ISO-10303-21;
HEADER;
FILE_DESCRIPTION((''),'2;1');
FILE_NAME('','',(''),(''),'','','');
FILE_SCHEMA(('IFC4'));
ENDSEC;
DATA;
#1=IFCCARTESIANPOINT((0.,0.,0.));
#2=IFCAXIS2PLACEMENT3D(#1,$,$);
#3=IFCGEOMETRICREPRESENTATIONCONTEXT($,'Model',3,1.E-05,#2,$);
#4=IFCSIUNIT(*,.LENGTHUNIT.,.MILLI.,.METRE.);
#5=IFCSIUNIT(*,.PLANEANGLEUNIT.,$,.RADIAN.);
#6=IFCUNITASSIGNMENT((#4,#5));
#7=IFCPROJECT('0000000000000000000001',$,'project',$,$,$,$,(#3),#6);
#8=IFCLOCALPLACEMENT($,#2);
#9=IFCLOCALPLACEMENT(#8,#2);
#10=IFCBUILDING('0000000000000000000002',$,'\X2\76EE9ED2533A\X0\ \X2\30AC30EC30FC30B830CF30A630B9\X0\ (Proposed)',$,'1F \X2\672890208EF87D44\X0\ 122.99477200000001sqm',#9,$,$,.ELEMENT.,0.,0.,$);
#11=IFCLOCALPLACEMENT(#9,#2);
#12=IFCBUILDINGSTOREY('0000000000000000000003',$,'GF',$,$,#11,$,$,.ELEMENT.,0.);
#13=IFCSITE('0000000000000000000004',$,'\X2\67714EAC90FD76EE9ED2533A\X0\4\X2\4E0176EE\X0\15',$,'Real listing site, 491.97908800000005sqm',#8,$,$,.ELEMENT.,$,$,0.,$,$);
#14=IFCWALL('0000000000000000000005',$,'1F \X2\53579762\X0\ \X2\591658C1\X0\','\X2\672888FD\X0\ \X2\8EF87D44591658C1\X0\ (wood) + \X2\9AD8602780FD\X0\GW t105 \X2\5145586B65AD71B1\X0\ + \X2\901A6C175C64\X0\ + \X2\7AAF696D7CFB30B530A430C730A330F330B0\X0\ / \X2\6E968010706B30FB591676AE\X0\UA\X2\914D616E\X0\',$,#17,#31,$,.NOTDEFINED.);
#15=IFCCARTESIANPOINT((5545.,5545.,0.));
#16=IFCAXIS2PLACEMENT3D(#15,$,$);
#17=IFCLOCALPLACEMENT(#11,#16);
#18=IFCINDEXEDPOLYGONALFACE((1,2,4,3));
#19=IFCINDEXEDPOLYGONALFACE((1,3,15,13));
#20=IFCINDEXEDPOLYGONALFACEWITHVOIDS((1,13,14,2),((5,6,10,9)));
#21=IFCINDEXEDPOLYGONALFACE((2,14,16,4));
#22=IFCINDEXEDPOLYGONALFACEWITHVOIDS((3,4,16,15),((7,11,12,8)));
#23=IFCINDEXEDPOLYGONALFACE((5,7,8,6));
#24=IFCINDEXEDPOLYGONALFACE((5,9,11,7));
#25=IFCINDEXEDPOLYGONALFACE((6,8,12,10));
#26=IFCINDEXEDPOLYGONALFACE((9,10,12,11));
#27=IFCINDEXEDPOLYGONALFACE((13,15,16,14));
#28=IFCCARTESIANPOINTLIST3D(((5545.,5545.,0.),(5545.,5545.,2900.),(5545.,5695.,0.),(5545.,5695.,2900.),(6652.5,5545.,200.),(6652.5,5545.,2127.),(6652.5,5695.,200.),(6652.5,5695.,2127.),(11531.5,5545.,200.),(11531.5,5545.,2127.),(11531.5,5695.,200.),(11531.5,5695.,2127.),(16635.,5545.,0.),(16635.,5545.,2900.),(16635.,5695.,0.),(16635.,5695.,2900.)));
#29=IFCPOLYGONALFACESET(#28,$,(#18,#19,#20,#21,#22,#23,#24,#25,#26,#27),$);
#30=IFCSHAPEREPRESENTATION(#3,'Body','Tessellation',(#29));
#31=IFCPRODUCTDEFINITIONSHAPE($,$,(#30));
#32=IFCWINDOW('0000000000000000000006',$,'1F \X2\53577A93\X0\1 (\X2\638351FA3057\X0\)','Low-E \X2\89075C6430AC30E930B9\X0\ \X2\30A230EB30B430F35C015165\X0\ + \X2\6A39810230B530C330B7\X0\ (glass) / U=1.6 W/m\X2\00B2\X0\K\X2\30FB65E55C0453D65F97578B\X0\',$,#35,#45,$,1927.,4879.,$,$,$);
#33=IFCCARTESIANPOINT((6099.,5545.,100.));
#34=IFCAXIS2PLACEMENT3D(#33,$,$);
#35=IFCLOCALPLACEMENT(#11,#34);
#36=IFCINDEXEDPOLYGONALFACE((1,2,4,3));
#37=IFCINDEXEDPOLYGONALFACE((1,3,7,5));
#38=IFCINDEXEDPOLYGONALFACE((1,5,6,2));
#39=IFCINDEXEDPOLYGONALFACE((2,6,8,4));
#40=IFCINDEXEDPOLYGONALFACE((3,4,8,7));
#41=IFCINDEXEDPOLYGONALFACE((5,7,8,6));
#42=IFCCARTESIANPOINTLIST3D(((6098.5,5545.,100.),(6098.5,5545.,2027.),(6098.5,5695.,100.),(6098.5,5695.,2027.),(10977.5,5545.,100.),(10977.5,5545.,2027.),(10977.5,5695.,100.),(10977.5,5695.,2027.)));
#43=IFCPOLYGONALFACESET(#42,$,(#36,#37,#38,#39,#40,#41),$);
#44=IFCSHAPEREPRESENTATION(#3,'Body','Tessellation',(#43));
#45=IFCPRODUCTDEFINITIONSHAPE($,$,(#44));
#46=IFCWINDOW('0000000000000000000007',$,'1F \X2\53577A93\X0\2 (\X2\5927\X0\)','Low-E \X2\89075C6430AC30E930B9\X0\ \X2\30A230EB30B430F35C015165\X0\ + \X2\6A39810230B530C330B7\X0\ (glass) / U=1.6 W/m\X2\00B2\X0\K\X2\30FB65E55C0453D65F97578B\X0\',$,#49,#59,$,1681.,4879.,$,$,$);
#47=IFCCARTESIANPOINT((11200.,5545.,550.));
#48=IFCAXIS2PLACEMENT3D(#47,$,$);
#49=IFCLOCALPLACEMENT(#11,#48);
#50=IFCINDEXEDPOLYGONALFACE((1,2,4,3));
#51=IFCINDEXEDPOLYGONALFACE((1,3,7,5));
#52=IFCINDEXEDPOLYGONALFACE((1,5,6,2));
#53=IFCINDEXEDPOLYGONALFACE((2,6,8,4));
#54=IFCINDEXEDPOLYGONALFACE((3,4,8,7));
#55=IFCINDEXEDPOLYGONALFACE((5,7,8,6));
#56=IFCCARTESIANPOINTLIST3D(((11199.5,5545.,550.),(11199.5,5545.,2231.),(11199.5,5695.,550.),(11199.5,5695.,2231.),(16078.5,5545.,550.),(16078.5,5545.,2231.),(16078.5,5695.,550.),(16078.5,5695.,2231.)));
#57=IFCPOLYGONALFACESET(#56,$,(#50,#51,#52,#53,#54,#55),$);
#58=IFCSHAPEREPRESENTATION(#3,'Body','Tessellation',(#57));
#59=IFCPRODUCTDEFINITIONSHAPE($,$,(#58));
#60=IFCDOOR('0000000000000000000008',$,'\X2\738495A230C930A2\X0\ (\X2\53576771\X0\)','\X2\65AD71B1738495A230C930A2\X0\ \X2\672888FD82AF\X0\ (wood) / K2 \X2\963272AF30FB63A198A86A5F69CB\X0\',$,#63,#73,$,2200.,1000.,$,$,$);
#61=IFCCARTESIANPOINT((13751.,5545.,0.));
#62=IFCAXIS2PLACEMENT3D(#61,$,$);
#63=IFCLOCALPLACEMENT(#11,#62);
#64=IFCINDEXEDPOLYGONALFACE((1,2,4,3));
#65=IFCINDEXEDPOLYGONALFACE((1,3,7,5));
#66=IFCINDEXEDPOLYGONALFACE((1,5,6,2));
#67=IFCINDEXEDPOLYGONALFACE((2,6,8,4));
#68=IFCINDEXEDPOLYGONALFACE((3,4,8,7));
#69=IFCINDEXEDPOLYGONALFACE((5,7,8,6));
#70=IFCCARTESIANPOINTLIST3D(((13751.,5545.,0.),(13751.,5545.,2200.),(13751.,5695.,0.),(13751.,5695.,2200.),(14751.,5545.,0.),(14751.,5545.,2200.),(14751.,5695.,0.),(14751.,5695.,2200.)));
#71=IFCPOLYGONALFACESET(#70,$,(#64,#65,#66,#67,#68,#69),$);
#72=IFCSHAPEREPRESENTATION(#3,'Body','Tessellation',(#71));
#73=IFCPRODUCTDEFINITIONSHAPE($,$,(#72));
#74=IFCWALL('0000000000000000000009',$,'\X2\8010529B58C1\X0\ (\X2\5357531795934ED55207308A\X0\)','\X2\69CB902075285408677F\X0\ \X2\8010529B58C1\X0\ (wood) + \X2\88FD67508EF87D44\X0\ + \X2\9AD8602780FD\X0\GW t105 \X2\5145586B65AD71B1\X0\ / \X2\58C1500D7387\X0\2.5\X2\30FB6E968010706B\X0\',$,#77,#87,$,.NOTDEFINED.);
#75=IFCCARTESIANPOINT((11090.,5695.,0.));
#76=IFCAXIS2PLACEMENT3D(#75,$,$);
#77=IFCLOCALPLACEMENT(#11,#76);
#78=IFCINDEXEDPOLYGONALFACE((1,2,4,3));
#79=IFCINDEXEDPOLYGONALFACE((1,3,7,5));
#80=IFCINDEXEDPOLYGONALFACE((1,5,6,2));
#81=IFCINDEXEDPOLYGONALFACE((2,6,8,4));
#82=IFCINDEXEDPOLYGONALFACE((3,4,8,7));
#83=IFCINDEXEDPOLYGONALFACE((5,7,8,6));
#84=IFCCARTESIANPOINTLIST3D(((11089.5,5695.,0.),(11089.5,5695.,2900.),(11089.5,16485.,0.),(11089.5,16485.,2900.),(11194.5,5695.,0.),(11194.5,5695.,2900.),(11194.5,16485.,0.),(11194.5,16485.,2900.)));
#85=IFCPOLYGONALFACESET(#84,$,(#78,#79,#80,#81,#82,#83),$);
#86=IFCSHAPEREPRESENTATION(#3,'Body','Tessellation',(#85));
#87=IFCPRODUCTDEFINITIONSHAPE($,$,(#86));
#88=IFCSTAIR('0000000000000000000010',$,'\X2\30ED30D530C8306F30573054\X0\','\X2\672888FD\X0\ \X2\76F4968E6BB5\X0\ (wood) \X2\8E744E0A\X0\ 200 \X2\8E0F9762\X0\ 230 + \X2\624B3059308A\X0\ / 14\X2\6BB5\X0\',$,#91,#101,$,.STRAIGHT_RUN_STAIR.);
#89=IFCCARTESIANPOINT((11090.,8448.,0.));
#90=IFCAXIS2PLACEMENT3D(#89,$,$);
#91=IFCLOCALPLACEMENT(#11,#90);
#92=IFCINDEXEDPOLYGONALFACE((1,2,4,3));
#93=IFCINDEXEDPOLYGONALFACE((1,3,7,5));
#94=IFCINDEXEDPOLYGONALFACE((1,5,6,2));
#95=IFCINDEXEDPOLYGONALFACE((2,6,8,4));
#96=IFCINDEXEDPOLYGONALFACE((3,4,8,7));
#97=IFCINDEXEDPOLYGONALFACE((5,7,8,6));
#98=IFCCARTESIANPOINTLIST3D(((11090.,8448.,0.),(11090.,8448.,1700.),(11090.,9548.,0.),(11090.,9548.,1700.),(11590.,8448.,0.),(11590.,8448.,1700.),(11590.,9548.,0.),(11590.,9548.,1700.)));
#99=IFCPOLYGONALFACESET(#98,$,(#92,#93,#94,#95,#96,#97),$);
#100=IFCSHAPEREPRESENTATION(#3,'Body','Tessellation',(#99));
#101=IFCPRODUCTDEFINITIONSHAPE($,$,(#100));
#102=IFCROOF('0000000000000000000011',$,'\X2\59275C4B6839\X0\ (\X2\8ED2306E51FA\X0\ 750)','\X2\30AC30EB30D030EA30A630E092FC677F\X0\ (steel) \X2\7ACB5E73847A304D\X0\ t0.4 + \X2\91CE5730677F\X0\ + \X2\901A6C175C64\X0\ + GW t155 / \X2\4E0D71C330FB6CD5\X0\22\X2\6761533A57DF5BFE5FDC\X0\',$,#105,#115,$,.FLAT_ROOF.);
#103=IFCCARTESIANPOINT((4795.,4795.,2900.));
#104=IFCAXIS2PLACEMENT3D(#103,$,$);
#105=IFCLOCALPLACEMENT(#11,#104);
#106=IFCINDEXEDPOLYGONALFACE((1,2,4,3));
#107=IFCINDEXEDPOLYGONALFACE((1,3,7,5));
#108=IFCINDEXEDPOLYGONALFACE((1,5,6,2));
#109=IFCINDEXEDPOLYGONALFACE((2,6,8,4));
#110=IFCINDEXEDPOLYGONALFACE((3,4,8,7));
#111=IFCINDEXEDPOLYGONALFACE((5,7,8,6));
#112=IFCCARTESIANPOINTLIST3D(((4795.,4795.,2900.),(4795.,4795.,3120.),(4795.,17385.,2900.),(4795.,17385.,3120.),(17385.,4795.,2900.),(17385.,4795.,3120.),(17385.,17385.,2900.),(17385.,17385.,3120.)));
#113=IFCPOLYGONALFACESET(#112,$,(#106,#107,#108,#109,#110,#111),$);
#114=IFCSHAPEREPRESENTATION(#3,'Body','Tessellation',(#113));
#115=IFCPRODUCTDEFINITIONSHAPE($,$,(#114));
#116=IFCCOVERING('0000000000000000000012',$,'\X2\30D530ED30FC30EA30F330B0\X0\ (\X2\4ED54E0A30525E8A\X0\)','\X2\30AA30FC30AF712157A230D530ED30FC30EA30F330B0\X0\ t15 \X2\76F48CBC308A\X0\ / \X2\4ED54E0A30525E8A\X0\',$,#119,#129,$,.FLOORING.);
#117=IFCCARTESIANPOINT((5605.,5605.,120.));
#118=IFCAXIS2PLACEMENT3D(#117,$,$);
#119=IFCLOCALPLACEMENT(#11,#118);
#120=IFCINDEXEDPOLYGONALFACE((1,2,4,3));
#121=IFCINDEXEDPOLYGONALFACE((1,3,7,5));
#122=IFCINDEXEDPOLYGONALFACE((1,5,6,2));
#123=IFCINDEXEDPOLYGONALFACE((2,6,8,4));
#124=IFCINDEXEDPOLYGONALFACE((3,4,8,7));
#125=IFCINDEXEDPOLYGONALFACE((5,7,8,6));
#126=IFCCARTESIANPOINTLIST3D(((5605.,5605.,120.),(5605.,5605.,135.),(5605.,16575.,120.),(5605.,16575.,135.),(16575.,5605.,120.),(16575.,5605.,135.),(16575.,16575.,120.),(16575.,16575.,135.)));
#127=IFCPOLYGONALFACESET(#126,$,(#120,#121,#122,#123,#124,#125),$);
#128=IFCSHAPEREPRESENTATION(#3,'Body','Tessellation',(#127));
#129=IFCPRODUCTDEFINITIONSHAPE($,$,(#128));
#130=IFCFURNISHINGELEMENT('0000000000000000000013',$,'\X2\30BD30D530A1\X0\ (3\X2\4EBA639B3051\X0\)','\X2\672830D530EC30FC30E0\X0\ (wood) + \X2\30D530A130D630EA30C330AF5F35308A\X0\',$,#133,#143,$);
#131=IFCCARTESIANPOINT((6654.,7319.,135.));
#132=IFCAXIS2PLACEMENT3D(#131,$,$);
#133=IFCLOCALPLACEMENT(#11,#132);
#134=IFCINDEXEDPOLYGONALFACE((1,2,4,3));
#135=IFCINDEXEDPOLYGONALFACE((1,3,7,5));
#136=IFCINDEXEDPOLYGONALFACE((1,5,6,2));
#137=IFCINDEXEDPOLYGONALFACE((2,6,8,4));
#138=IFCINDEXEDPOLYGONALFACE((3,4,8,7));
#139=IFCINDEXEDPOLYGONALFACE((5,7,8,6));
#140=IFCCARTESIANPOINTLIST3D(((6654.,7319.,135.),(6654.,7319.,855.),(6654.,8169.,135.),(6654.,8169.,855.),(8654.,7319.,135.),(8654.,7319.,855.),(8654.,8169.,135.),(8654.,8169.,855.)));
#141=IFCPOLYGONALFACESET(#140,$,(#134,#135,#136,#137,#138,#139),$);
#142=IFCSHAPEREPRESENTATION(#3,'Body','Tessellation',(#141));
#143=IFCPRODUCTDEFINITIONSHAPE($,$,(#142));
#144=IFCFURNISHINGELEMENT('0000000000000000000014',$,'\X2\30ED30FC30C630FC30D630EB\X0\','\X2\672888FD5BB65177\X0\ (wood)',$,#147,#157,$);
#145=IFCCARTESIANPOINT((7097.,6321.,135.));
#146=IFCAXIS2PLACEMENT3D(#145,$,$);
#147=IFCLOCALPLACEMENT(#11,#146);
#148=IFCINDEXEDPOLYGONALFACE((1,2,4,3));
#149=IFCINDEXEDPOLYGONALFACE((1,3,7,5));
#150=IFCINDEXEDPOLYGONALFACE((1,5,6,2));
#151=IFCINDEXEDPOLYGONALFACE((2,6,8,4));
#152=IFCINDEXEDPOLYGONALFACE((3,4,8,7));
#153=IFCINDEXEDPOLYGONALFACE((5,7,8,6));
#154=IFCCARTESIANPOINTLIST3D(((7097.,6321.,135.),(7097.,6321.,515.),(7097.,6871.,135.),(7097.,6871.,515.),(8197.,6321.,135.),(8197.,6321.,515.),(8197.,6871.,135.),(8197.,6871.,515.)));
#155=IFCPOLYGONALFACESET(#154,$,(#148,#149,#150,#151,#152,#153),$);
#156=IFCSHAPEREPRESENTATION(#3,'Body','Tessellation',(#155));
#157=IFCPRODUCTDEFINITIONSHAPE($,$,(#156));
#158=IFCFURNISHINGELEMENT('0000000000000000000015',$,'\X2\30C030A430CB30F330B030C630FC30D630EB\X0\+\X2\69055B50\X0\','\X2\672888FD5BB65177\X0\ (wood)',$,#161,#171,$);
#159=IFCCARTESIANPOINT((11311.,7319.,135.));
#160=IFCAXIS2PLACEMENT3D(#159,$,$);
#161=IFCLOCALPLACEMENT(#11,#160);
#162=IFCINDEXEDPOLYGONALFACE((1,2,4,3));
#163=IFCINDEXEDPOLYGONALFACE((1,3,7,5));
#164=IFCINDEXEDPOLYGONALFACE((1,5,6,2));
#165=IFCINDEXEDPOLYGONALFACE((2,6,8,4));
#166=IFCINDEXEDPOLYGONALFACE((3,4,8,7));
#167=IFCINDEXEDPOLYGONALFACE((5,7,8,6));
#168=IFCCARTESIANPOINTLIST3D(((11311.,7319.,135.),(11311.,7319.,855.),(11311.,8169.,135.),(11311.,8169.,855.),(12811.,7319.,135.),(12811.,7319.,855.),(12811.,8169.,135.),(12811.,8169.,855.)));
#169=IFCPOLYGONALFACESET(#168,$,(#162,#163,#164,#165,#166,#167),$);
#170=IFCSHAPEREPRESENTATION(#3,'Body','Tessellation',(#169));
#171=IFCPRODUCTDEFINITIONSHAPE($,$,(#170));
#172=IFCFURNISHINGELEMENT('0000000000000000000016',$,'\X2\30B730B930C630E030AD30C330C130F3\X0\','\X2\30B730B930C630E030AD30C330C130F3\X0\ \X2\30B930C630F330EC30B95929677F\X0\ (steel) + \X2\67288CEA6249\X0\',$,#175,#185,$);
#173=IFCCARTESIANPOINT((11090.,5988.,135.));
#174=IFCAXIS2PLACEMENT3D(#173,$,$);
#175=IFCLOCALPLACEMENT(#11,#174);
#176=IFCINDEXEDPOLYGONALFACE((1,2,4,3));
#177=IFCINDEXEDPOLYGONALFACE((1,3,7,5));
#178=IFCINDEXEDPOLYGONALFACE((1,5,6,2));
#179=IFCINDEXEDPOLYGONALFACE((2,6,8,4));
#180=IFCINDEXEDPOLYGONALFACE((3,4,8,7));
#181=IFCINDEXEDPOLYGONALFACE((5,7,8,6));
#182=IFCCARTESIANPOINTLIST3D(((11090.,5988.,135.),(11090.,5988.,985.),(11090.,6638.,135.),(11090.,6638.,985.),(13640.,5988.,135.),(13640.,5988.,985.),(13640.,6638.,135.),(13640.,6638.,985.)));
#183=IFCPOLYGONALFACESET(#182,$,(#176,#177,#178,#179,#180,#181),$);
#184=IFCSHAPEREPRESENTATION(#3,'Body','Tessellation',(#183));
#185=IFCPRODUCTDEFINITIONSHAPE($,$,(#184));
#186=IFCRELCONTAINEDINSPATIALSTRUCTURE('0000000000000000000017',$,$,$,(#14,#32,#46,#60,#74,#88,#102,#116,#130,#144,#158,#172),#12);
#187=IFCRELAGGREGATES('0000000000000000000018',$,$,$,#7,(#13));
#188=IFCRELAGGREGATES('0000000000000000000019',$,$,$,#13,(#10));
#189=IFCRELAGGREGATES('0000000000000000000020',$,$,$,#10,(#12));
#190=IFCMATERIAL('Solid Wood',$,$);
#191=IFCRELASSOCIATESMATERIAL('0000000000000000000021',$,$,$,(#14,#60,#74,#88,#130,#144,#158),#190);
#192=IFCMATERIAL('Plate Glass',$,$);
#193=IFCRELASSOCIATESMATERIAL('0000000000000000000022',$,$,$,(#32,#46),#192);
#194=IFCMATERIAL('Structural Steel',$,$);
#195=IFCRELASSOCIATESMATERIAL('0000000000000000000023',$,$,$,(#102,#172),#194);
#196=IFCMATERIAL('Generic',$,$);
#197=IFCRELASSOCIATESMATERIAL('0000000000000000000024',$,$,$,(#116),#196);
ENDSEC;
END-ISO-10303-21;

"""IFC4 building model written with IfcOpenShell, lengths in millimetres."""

from ifc_helpers import new_model, si_unit, frame, frame_2d, origin, place, context, project, spatial, rectangle, extrude, material, element, fill, save


model = new_model("IFC4")

# Units and contexts
model_context = context("Model", 3, precision=1e-05, world=origin())
ifc_project = project(units=[si_unit("LENGTHUNIT", "METRE", prefix="MILLI"), si_unit("PLANEANGLEUNIT", "RADIAN")], contexts=[model_context])

# Site, building, storey
site_placement = place(None, origin())
site = spatial("IfcSite", under=ifc_project, at=site_placement, Name="東京都目黒区4丁目15", ObjectType="Real listing site, 491.97908800000005sqm", CompositionType="ELEMENT", RefElevation=0.0)
building_placement = place(site_placement, origin())
building = spatial("IfcBuilding", under=site, at=building_placement, Name="目黒区 ガレージハウス (Proposed)", ObjectType="1F 木造軸組 122.99477200000001sqm", CompositionType="ELEMENT", ElevationOfRefHeight=0.0, ElevationOfTerrain=0.0)
storey_placement = place(building_placement, origin())
storey = spatial("IfcBuildingStorey", under=building, at=storey_placement, Name="GF", CompositionType="ELEMENT", Elevation=0.0)

# Shared definitions
ifc_material_1 = material(Name="Solid Wood")

# Wall, openings, windows, door
wall_1_placement = place(storey_placement, frame((5545.0, 5545.0, 0.0)))
wall_1 = element("IfcWall", 1, at=wall_1_placement, inside=storey, material=ifc_material_1, Name="1F 南面 外壁", Description="木製 軸組外壁 (wood) + 高性能GW t105 充填断熱 + 通気層 + 窯業系サイディング / 準耐火・外皮UA配慮", PredefinedType="NOTDEFINED", context=model_context, shape_type="SweptSolid", body=[
    extrude(rectangle(XDim=11090.0, YDim=150.0, at=frame_2d((5545.0, 75.0))), frame((5545.0, 5545.0, 0.0)), (0.0, 0.0, 1.0), 2900.0),
])
opening_1_placement = place(storey_placement, frame((6099.0, 5545.0, 100.0)))
opening_1 = element("IfcOpeningElement", 2, at=opening_1_placement, cuts=wall_1, PredefinedType="NOTDEFINED", context=model_context, shape_type="SweptSolid", body=[
    extrude(rectangle(XDim=4879.0, YDim=150.0, at=frame_2d((2439.0, 75.0))), frame((6099.0, 5545.0, 100.0)), (0.0, 0.0, 1.0), 1927.0),
])
opening_2_placement = place(storey_placement, frame((11200.0, 5545.0, 550.0)))
opening_2 = element("IfcOpeningElement", 3, at=opening_2_placement, cuts=wall_1, PredefinedType="NOTDEFINED", context=model_context, shape_type="SweptSolid", body=[
    extrude(rectangle(XDim=4879.0, YDim=150.0, at=frame_2d((2439.0, 75.0))), frame((11200.0, 5545.0, 550.0)), (0.0, 0.0, 1.0), 1681.0),
])
opening_3_placement = place(storey_placement, frame((13751.0, 5545.0, 0.0)))
opening_3 = element("IfcOpeningElement", 4, at=opening_3_placement, cuts=wall_1, PredefinedType="NOTDEFINED", context=model_context, shape_type="SweptSolid", body=[
    extrude(rectangle(XDim=1000.0, YDim=150.0, at=frame_2d((500.0, 75.0))), frame((13751.0, 5545.0, 0.0)), (0.0, 0.0, 1.0), 2200.0),
])
ifc_material_2 = material(Name="Plate Glass")
window_1_placement = place(storey_placement, frame((6099.0, 5545.0, 100.0)))
window_1 = element("IfcWindow", 5, at=window_1_placement, inside=storey, material=ifc_material_2, Name="1F 南窓1 (掃出し)", Description="Low-E 複層ガラス アルゴン封入 + 樹脂サッシ (glass) / U=1.6 W/m²K・日射取得型", OverallHeight=1927.0, OverallWidth=4879.0, context=model_context, shape_type="SweptSolid", body=[
    extrude(rectangle(XDim=4879.0, YDim=150.0, at=frame_2d((2439.0, 75.0))), frame((6099.0, 5545.0, 100.0)), (0.0, 0.0, 1.0), 1927.0),
])
fill(opening_1, window_1)
window_2_placement = place(storey_placement, frame((11200.0, 5545.0, 550.0)))
window_2 = element("IfcWindow", 6, at=window_2_placement, inside=storey, material=ifc_material_2, Name="1F 南窓2 (大)", Description="Low-E 複層ガラス アルゴン封入 + 樹脂サッシ (glass) / U=1.6 W/m²K・日射取得型", OverallHeight=1681.0, OverallWidth=4879.0, context=model_context, shape_type="SweptSolid", body=[
    extrude(rectangle(XDim=4879.0, YDim=150.0, at=frame_2d((2439.0, 75.0))), frame((11200.0, 5545.0, 550.0)), (0.0, 0.0, 1.0), 1681.0),
])
fill(opening_2, window_2)
door_placement = place(storey_placement, frame((13751.0, 5545.0, 0.0)))
door = element("IfcDoor", 7, at=door_placement, inside=storey, material=ifc_material_1, Name="玄関ドア (南東)", Description="断熱玄関ドア 木製芯 (wood) / K2 防犯・採風機構", OverallHeight=2200.0, OverallWidth=1000.0, context=model_context, shape_type="SweptSolid", body=[
    extrude(rectangle(XDim=1000.0, YDim=150.0, at=frame_2d((500.0, 75.0))), frame((13751.0, 5545.0, 0.0)), (0.0, 0.0, 1.0), 2200.0),
])
fill(opening_3, door)

# Wall
wall_2_placement = place(storey_placement, frame((11090.0, 5695.0, 0.0)))
element("IfcWall", 8, at=wall_2_placement, inside=storey, material=ifc_material_1, Name="耐力壁 (南北間仕切り)", Description="構造用合板 耐力壁 (wood) + 製材軸組 + 高性能GW t105 充填断熱 / 壁倍率2.5・準耐火", PredefinedType="NOTDEFINED", context=model_context, shape_type="SweptSolid", body=[
    extrude(rectangle(XDim=105.0, YDim=10790.0, at=frame_2d((52.0, 5395.0))), frame((11090.0, 5695.0, 0.0)), (0.0, 0.0, 1.0), 2900.0),
])

# Stair
stair_placement = place(storey_placement, frame((11090.0, 8448.0, 0.0)))
element("IfcStair", 9, at=stair_placement, inside=storey, material=ifc_material_1, Name="ロフトはしご", Description="木製 直階段 (wood) 蹴上 200 踏面 230 + 手すり / 14段", PredefinedType="STRAIGHT_RUN_STAIR", context=model_context, shape_type="SweptSolid", body=[
    extrude(rectangle(XDim=500.0, YDim=1100.0, at=frame_2d((250.0, 550.0))), frame((11090.0, 8448.0, 0.0)), (0.0, 0.0, 1.0), 1700.0),
])

# Roof
ifc_material_3 = material(Name="Structural Steel")
roof_placement = place(storey_placement, frame((4795.0, 4795.0, 2900.0)))
element("IfcRoof", 10, at=roof_placement, inside=storey, material=ifc_material_3, Name="大屋根 (軒の出 750)", Description="ガルバリウム鋼板 (steel) 立平葺き t0.4 + 野地板 + 通気層 + GW t155 / 不燃・法22条区域対応", PredefinedType="FLAT_ROOF", context=model_context, shape_type="SweptSolid", body=[
    extrude(rectangle(XDim=12590.0, YDim=12590.0, at=frame_2d((6295.0, 6295.0))), frame((4795.0, 4795.0, 2900.0)), (0.0, 0.0, 1.0), 220.0),
])

# Covering
ifc_material_4 = material(Name="Generic")
covering_placement = place(storey_placement, frame((5605.0, 5605.0, 120.0)))
element("IfcCovering", 11, at=covering_placement, inside=storey, material=ifc_material_4, Name="フローリング (仕上げ床)", Description="オーク無垢フローリング t15 直貼り / 仕上げ床", PredefinedType="FLOORING", context=model_context, shape_type="SweptSolid", body=[
    extrude(rectangle(XDim=10970.0, YDim=10970.0, at=frame_2d((5485.0, 5485.0))), frame((5605.0, 5605.0, 120.0)), (0.0, 0.0, 1.0), 15.0),
])

# Furnishing elements
furnishing_1_placement = place(storey_placement, frame((6654.0, 7319.0, 135.0)))
element("IfcFurnishingElement", 12, at=furnishing_1_placement, inside=storey, material=ifc_material_1, Name="ソファ (3人掛け)", Description="木フレーム (wood) + ファブリック張り", context=model_context, shape_type="SweptSolid", body=[
    extrude(rectangle(XDim=2000.0, YDim=850.0, at=frame_2d((1000.0, 425.0))), frame((6654.0, 7319.0, 135.0)), (0.0, 0.0, 1.0), 720.0),
])
furnishing_2_placement = place(storey_placement, frame((7097.0, 6321.0, 135.0)))
element("IfcFurnishingElement", 13, at=furnishing_2_placement, inside=storey, material=ifc_material_1, Name="ローテーブル", Description="木製家具 (wood)", context=model_context, shape_type="SweptSolid", body=[
    extrude(rectangle(XDim=1100.0, YDim=550.0, at=frame_2d((550.0, 275.0))), frame((7097.0, 6321.0, 135.0)), (0.0, 0.0, 1.0), 380.0),
])
furnishing_3_placement = place(storey_placement, frame((11311.0, 7319.0, 135.0)))
element("IfcFurnishingElement", 14, at=furnishing_3_placement, inside=storey, material=ifc_material_1, Name="ダイニングテーブル+椅子", Description="木製家具 (wood)", context=model_context, shape_type="SweptSolid", body=[
    extrude(rectangle(XDim=1500.0, YDim=850.0, at=frame_2d((750.0, 425.0))), frame((11311.0, 7319.0, 135.0)), (0.0, 0.0, 1.0), 720.0),
])
furnishing_4_placement = place(storey_placement, frame((11090.0, 5988.0, 135.0)))
element("IfcFurnishingElement", 15, at=furnishing_4_placement, inside=storey, material=ifc_material_3, Name="システムキッチン", Description="システムキッチン ステンレス天板 (steel) + 木質扉", context=model_context, shape_type="SweptSolid", body=[
    extrude(rectangle(XDim=2550.0, YDim=650.0, at=frame_2d((1275.0, 325.0))), frame((11090.0, 5988.0, 135.0)), (0.0, 0.0, 1.0), 850.0),
])

save(model, "model.ifc")
